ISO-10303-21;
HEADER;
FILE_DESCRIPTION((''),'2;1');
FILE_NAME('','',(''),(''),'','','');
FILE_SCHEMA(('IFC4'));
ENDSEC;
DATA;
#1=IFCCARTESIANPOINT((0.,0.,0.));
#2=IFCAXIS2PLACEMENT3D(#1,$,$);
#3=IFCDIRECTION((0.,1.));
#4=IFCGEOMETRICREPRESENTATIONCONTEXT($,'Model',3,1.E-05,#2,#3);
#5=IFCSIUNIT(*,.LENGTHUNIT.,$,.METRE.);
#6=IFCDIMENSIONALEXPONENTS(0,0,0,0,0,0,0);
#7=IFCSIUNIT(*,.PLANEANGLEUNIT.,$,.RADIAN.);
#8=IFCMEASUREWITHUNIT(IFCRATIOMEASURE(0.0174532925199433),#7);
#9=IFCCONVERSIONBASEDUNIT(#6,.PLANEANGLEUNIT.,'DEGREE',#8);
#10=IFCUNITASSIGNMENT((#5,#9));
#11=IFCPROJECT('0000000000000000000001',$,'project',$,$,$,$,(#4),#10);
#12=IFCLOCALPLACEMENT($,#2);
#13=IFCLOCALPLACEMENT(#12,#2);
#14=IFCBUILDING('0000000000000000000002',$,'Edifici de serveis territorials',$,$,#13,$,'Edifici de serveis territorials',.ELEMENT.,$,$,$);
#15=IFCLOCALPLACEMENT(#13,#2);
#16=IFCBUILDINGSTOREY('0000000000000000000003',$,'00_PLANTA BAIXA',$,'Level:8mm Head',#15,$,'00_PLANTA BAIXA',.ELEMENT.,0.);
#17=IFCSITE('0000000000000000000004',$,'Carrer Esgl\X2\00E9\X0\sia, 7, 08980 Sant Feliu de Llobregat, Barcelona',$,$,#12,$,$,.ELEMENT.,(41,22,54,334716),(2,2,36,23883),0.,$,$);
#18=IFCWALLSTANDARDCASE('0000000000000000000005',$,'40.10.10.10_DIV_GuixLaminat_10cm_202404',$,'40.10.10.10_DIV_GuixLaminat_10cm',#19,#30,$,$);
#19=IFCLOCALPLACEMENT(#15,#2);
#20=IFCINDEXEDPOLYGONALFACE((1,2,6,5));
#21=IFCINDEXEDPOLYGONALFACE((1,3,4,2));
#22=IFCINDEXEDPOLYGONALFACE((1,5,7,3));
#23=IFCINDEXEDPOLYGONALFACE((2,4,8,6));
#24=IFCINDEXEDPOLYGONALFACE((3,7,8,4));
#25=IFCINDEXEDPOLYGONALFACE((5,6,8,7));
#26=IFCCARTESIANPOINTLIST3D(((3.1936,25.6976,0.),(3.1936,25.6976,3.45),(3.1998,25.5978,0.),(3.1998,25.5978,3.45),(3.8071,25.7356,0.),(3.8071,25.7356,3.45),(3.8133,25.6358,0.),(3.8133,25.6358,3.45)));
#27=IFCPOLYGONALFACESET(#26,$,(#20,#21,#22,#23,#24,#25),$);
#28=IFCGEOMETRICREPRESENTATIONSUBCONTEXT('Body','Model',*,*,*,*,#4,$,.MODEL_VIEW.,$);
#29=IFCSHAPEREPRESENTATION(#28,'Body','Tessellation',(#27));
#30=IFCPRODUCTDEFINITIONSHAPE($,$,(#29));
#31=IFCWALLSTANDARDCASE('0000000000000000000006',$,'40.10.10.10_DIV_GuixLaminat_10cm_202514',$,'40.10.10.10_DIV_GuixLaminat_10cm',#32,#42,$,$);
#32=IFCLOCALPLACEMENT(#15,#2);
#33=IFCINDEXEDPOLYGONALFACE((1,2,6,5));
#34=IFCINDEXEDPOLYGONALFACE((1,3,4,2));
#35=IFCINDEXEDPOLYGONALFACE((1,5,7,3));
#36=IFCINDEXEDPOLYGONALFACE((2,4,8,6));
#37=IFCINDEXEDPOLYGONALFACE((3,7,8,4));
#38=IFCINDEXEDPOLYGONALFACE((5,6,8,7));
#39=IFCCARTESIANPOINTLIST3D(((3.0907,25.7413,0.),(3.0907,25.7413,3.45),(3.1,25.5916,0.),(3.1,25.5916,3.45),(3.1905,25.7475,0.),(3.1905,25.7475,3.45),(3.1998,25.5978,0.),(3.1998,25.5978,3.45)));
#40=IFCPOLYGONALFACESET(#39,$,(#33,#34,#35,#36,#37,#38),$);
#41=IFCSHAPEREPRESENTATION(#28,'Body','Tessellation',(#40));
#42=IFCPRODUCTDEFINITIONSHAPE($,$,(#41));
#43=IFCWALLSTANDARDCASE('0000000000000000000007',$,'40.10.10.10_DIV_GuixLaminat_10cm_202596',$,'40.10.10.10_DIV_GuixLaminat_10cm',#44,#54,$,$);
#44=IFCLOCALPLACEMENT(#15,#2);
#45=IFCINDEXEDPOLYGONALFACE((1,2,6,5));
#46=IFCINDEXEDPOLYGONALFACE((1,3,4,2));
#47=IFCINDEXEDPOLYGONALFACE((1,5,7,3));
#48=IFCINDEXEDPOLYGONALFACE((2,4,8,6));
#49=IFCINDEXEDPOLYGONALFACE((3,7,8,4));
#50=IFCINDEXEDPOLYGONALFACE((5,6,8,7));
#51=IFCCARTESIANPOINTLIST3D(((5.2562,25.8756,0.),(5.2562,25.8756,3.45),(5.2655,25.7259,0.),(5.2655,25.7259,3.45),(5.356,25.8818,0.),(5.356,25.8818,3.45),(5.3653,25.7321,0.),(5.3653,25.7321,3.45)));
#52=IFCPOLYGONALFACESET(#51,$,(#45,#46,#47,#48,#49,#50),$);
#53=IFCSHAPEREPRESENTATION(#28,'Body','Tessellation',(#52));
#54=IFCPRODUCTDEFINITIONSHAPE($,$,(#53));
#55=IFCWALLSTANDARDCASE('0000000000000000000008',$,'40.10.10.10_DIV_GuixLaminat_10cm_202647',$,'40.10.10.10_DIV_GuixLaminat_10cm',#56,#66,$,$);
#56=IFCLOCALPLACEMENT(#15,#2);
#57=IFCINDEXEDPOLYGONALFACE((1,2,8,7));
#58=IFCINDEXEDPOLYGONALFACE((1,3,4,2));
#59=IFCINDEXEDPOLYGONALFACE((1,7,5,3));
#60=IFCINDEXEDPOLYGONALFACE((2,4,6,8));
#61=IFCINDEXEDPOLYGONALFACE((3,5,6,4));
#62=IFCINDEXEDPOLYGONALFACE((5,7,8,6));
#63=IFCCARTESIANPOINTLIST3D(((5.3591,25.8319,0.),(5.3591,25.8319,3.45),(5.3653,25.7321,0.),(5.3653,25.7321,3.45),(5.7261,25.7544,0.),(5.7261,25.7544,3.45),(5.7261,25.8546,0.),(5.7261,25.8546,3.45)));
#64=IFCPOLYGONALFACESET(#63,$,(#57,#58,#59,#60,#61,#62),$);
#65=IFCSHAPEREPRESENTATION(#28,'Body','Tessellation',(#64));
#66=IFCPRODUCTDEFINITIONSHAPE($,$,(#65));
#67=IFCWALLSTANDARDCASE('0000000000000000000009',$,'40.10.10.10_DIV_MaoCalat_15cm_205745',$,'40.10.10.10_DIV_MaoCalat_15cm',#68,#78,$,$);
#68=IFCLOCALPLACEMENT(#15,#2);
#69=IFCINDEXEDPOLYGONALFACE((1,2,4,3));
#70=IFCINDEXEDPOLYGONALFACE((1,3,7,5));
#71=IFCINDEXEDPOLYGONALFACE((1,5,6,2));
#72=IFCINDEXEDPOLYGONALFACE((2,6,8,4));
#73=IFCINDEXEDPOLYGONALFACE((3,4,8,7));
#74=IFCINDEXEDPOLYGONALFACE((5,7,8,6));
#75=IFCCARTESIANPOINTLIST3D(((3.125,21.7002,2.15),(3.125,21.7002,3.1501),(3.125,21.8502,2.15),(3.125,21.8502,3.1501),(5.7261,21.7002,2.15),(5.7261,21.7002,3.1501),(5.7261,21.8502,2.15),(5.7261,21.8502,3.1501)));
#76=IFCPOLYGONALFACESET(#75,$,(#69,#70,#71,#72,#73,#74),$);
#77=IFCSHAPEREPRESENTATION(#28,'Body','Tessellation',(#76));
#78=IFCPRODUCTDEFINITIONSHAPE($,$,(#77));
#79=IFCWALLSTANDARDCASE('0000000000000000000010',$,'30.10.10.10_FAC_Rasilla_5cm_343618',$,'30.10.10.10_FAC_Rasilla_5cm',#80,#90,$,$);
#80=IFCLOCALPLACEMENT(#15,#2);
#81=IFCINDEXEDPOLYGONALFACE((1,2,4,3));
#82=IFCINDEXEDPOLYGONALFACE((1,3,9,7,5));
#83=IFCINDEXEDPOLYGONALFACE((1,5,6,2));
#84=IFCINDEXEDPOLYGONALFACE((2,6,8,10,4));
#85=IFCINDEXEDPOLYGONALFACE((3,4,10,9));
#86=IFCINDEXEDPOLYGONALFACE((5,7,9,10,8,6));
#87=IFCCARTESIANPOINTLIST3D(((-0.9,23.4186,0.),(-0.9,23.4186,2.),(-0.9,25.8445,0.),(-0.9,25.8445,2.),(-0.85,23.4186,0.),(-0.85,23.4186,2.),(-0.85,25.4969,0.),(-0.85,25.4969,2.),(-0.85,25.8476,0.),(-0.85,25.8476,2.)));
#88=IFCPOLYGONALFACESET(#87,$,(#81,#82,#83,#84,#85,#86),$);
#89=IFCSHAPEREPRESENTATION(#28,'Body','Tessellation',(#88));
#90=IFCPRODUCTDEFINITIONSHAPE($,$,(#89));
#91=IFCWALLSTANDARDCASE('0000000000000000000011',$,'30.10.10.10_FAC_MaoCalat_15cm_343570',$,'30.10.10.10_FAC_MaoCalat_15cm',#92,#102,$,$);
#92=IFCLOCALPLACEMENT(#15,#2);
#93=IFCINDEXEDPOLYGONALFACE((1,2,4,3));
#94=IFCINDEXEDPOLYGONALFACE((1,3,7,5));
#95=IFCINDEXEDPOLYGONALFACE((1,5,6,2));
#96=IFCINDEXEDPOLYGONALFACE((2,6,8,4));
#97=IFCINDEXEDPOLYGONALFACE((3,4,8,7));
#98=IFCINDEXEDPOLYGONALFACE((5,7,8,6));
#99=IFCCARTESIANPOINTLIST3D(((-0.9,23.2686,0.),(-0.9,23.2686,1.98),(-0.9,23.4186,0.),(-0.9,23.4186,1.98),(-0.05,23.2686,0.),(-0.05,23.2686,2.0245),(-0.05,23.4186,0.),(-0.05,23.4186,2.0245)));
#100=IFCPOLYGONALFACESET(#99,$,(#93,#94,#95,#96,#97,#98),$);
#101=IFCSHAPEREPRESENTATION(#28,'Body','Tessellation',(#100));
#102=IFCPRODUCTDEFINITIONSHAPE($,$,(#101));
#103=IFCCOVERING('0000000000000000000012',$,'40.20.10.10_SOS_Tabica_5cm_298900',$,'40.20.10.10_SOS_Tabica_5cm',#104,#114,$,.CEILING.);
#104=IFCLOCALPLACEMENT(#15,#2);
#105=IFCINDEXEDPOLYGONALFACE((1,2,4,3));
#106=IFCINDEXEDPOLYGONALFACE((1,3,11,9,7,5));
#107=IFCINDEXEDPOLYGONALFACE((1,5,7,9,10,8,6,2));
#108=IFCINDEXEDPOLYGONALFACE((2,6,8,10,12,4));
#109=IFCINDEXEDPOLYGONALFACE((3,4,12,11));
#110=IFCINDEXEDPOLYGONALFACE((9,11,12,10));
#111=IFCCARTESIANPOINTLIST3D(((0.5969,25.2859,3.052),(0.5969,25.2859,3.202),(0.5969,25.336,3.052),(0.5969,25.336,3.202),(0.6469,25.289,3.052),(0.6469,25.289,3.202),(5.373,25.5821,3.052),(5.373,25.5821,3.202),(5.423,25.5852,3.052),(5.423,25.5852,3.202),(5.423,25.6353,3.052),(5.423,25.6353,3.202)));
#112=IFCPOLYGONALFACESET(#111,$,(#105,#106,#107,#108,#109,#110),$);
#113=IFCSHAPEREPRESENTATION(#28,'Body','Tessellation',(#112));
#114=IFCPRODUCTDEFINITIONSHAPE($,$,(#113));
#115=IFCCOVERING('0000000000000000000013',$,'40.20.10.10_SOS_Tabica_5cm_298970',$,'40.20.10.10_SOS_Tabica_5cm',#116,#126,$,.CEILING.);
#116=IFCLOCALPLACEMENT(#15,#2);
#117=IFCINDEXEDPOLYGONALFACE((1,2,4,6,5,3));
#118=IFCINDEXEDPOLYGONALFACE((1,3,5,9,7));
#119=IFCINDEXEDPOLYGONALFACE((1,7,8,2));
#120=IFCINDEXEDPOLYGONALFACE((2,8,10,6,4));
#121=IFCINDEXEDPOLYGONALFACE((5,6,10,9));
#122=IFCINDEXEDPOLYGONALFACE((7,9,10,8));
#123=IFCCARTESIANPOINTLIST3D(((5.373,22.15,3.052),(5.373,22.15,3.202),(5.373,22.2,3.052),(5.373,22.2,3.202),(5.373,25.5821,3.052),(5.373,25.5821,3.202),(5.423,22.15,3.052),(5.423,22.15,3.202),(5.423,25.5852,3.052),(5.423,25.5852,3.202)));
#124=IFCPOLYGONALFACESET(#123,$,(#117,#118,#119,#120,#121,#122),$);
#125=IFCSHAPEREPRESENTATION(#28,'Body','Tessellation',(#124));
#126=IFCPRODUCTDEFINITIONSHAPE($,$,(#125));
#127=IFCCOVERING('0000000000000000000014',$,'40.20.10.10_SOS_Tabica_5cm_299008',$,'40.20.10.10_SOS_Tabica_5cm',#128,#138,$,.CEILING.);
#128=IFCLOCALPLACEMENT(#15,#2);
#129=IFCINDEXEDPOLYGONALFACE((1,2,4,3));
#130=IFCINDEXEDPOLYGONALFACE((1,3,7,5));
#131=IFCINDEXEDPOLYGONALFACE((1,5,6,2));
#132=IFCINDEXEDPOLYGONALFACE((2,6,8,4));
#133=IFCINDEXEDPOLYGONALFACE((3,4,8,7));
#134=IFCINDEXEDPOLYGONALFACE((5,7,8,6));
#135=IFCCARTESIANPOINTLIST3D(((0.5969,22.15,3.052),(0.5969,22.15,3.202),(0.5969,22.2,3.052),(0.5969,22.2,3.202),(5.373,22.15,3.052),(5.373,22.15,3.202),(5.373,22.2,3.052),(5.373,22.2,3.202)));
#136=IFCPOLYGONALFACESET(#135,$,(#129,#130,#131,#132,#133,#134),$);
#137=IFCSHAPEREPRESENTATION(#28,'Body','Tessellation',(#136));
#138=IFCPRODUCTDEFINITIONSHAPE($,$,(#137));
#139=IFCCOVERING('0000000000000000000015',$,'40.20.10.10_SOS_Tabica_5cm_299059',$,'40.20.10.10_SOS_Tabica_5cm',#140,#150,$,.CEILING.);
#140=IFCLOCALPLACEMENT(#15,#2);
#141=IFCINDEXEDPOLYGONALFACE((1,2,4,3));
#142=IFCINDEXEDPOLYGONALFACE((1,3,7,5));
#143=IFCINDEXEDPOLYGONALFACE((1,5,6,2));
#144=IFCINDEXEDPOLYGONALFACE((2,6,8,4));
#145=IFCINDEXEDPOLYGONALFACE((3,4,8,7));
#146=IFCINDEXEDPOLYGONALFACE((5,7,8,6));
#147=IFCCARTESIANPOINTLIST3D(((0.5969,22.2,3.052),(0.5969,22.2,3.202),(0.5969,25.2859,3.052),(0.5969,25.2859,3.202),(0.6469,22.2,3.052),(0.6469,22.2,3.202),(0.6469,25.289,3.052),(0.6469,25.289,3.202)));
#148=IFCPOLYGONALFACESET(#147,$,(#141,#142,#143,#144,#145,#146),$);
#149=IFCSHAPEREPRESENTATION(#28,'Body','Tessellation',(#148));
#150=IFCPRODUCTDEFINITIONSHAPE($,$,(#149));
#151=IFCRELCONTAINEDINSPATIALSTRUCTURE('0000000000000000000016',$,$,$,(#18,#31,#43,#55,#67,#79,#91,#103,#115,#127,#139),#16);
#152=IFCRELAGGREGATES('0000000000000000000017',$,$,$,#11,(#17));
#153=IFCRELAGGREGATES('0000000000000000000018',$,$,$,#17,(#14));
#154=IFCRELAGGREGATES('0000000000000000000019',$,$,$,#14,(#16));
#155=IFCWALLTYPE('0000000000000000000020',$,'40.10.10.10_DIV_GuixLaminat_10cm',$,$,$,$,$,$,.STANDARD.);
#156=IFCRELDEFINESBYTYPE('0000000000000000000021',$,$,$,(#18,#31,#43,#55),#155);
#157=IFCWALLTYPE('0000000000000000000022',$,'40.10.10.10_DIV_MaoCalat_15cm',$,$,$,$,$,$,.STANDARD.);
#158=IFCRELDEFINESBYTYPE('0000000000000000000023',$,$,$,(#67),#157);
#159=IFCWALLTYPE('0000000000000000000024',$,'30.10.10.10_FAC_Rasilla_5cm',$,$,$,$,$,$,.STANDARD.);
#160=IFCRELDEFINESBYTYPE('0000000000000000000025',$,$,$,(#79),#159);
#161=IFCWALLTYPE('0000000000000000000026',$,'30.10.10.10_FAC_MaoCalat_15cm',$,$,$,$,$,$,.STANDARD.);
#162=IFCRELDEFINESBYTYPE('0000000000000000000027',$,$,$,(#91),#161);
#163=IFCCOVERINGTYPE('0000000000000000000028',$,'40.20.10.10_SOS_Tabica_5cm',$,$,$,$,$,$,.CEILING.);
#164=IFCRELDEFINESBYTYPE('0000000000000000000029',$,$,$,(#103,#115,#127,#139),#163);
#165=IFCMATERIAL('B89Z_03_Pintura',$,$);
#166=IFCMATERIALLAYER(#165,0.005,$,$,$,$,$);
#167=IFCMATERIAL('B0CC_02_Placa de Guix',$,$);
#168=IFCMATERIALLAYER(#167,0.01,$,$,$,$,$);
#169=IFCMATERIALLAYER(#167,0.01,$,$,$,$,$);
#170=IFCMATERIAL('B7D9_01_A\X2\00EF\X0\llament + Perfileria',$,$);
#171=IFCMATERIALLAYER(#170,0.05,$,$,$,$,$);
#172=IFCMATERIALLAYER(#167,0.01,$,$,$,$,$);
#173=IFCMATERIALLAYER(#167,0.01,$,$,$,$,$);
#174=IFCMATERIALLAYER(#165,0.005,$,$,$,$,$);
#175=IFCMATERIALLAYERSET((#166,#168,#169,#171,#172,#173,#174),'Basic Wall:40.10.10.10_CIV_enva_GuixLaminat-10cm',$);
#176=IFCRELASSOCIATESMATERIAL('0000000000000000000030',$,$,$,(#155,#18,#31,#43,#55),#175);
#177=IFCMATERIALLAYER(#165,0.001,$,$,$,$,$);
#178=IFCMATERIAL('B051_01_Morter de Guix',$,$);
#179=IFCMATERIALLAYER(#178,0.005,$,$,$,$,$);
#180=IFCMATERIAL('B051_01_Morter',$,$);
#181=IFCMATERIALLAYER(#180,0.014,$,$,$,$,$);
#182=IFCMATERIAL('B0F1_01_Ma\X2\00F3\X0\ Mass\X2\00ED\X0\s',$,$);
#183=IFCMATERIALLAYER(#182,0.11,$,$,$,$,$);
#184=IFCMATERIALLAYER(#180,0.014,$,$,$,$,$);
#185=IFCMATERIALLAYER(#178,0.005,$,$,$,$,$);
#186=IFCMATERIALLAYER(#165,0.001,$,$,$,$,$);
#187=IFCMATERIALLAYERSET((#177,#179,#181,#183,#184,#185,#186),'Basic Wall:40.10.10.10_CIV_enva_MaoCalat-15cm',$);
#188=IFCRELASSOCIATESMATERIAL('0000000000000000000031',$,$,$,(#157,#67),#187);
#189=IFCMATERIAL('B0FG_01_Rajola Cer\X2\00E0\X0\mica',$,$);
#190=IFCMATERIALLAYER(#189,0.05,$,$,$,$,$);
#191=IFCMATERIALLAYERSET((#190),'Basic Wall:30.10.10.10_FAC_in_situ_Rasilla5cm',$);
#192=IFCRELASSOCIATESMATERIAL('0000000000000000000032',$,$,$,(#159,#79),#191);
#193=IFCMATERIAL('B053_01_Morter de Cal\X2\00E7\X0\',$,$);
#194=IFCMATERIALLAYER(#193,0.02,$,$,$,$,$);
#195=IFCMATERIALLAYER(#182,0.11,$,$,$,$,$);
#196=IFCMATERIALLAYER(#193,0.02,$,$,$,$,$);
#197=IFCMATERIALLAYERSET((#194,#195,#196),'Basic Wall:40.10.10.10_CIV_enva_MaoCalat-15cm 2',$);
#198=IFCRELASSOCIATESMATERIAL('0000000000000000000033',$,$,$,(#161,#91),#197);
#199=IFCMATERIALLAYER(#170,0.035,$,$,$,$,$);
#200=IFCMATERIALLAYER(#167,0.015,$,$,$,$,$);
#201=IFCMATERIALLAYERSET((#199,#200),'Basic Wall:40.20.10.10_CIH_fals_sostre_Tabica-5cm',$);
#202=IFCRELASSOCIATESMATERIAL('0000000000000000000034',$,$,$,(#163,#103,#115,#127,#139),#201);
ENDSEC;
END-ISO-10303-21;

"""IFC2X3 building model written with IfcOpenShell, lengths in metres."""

from ifc_helpers import new_model, entity, si_unit, converted_unit, direction, frame, frame_2d, origin, place, context, subcontext, project, spatial, polyline, rectangle, outline, extrude, clip, bounded_halfspace, material, layer, layer_set, layer_usage, type_object, element, save


model = new_model("IFC2X3")

# Units and contexts
model_context = context("Model", 3, precision=1e-05, world=origin(), true_north=direction((0.0, 1.0)))
body_context = subcontext(model_context, "Body", "Model", "MODEL_VIEW")
ifc_project = project(units=[si_unit("LENGTHUNIT", "METRE"), converted_unit("PLANEANGLEUNIT", "DEGREE", entity("IfcRatioMeasure", 0.0174532925199433), si_unit("PLANEANGLEUNIT", "RADIAN"), dimensions=[0, 0, 0, 0, 0, 0, 0])], contexts=[model_context])

# Site, building, storey
site_placement = place(None, origin())
site = spatial("IfcSite", under=ifc_project, at=site_placement, Name="Carrer Església, 7, 08980 Sant Feliu de Llobregat, Barcelona", CompositionType="ELEMENT", RefLatitude=(41, 22, 54, 334716), RefLongitude=(2, 2, 36, 23883), RefElevation=0.0)
building_placement = place(site_placement, origin())
building = spatial("IfcBuilding", under=site, at=building_placement, Name="Edifici de serveis territorials", LongName="Edifici de serveis territorials", CompositionType="ELEMENT")
storey_placement = place(building_placement, origin())
storey = spatial("IfcBuildingStorey", under=building, at=storey_placement, Name="00_PLANTA BAIXA", ObjectType="Level:8mm Head", LongName="00_PLANTA BAIXA", CompositionType="ELEMENT", Elevation=0.0)

# Shared definitions
ifc_material_1 = material(Name="B053_01_Morter de Calç")
ifc_material_2 = material(Name="B0F1_01_Maó Massís")

# Shared definitions
ifc_material_3 = material(Name="B89Z_03_Pintura")
ifc_layer_1 = layer(ifc_material_3, 0.005)
ifc_material_4 = material(Name="B0CC_02_Placa de Guix")
ifc_layer_2 = layer(ifc_material_4, 0.01)
ifc_layer_3 = layer(ifc_material_4, 0.01)
ifc_material_5 = material(Name="B7D9_01_Aïllament + Perfileria")
ifc_layer_4 = layer(ifc_material_5, 0.05)
ifc_layer_5 = layer(ifc_material_4, 0.01)
ifc_layer_6 = layer(ifc_material_4, 0.01)
ifc_layer_7 = layer(ifc_material_3, 0.005)
ifc_layer_set_1 = layer_set([ifc_layer_1, ifc_layer_2, ifc_layer_3, ifc_layer_4, ifc_layer_5, ifc_layer_6, ifc_layer_7], Name="Basic Wall:40.10.10.10_CIV_enva_GuixLaminat-10cm")
wall_type_1 = type_object("IfcWallType", Name="40.10.10.10_DIV_GuixLaminat_10cm", PredefinedType="STANDARD", material=ifc_layer_set_1)

# Walls
ifc_layer_usage_1 = layer_usage(ifc_layer_set_1, "AXIS2", "NEGATIVE", 0.05)
wall_1_placement = place(storey_placement, frame((3.8102, 25.6857, 0.0), z_axis=(0.0, 0.0, 1.0), x_axis=(-0.998083, -0.061896, 0.0)))
element("IfcWallStandardCase", 1, at=wall_1_placement, inside=storey, type_object=wall_type_1, material=ifc_layer_usage_1, Name="40.10.10.10_DIV_GuixLaminat_10cm_202404", ObjectType="40.10.10.10_DIV_GuixLaminat_10cm", context=body_context, shape_type="Clipping", body=[
    clip(extrude(rectangle(XDim=0.6146, YDim=0.1, at=frame_2d((0.3073, 0.0), x_axis=(-1.0, 0.0))), origin(), (0.0, 0.0, 1.0), 3.45), bounded_halfspace(frame((0.0, -0.05, 3.45), z_axis=(0.0, 0.0, -1.0), x_axis=(0.036428, 0.999336, 0.0)), True, frame((0.0, -0.05, 3.45)), polyline([(0.0, 0.0), (0.6146, 0.0), (0.6146, 0.1), (0.0, 0.1), (0.0, 0.0)]))),
])
ifc_layer_usage_2 = layer_usage(ifc_layer_set_1, "AXIS2", "NEGATIVE", 0.05)
wall_2_placement = place(storey_placement, frame((3.1499, 25.5947, 0.0), z_axis=(0.0, 0.0, 1.0), x_axis=(-0.061896, 0.998083, 0.0)))
element("IfcWallStandardCase", 2, at=wall_2_placement, inside=storey, type_object=wall_type_1, material=ifc_layer_usage_2, Name="40.10.10.10_DIV_GuixLaminat_10cm_202514", ObjectType="40.10.10.10_DIV_GuixLaminat_10cm", context=body_context, shape_type="Clipping", body=[
    clip(extrude(rectangle(XDim=0.15, YDim=0.1, at=frame_2d((0.075, 0.0), x_axis=(-1.0, 0.0))), origin(), (0.0, 0.0, 1.0), 3.45), bounded_halfspace(frame((0.0, -0.05, 3.45), z_axis=(0.0, 0.0, -1.0), x_axis=(-0.999336, 0.036428, 0.0)), True, frame((0.0, -0.05, 3.45)), polyline([(0.0, 0.0), (0.1, 0.0), (0.15, 0.0), (0.15, 0.1), (0.0, 0.1), (0.0, 0.0)]))),
])
ifc_layer_usage_3 = layer_usage(ifc_layer_set_1, "AXIS2", "NEGATIVE", 0.05)
wall_3_placement = place(storey_placement, frame((5.3061, 25.8787, 0.0), z_axis=(0.0, 0.0, 1.0), x_axis=(0.061896, -0.998083, 0.0)))
element("IfcWallStandardCase", 3, at=wall_3_placement, inside=storey, type_object=wall_type_1, material=ifc_layer_usage_3, Name="40.10.10.10_DIV_GuixLaminat_10cm_202596", ObjectType="40.10.10.10_DIV_GuixLaminat_10cm", context=body_context, shape_type="Clipping", body=[
    clip(extrude(rectangle(XDim=0.15, YDim=0.1, at=frame_2d((0.075, 0.0), x_axis=(-1.0, 0.0))), origin(), (0.0, 0.0, 1.0), 3.45), bounded_halfspace(frame((0.0, -0.05, 3.45), z_axis=(0.0, 0.0, -1.0), x_axis=(0.999336, -0.036428, 0.0)), True, frame((0.0, -0.05, 3.45)), polyline([(0.0, 0.0), (0.15, 0.0), (0.15, 0.1), (0.05, 0.1), (0.0, 0.1), (0.0, 0.0)]))),
])
ifc_layer_usage_4 = layer_usage(ifc_layer_set_1, "AXIS2", "NEGATIVE", 0.05)
wall_4_placement = place(storey_placement, frame((5.3622, 25.782, 0.0), z_axis=(0.0, 0.0, 1.0), x_axis=(0.998083, 0.061896, 0.0)))
element("IfcWallStandardCase", 4, at=wall_4_placement, inside=storey, type_object=wall_type_1, material=ifc_layer_usage_4, Name="40.10.10.10_DIV_GuixLaminat_10cm_202647", ObjectType="40.10.10.10_DIV_GuixLaminat_10cm", context=body_context, shape_type="Clipping", body=[
    clip(extrude(outline(polyline([(0.3615, -0.05), (0.3677, 0.05), (0.0, 0.05), (0.0, -0.05), (0.3615, -0.05)])), origin(), (0.0, 0.0, 1.0), 3.45), bounded_halfspace(frame((0.0, -0.05, 3.45), z_axis=(0.0, 0.0, -1.0), x_axis=(-0.036428, -0.999336, 0.0)), True, frame((0.0, -0.05, 3.45)), polyline([(0.0, 0.0), (0.3615, 0.0), (0.3677, 0.1), (0.0, 0.1), (0.0, 0.0)]))),
])
ifc_layer_8 = layer(ifc_material_3, 0.001)
ifc_material_6 = material(Name="B051_01_Morter de Guix")
ifc_layer_9 = layer(ifc_material_6, 0.005)
ifc_material_7 = material(Name="B051_01_Morter")
ifc_layer_10 = layer(ifc_material_7, 0.014)
ifc_layer_11 = layer(ifc_material_2, 0.11)
ifc_layer_12 = layer(ifc_material_7, 0.014)
ifc_layer_13 = layer(ifc_material_6, 0.005)
ifc_layer_14 = layer(ifc_material_3, 0.001)
ifc_layer_set_2 = layer_set([ifc_layer_8, ifc_layer_9, ifc_layer_10, ifc_layer_11, ifc_layer_12, ifc_layer_13, ifc_layer_14], Name="Basic Wall:40.10.10.10_CIV_enva_MaoCalat-15cm")
ifc_layer_usage_5 = layer_usage(ifc_layer_set_2, "AXIS2", "NEGATIVE", 0.075)
wall_type_2 = type_object("IfcWallType", Name="40.10.10.10_DIV_MaoCalat_15cm", PredefinedType="STANDARD", material=ifc_layer_set_2)
wall_5_placement = place(storey_placement, frame((5.7261, 21.7752, 2.15), z_axis=(0.0, 0.0, 1.0), x_axis=(-1.0, 0.0, 0.0)))
element("IfcWallStandardCase", 5, at=wall_5_placement, inside=storey, type_object=wall_type_2, material=ifc_layer_usage_5, Name="40.10.10.10_DIV_MaoCalat_15cm_205745", ObjectType="40.10.10.10_DIV_MaoCalat_15cm", context=body_context, shape_type="SweptSolid", body=[
    extrude(rectangle(XDim=2.6011, YDim=0.15, at=frame_2d((1.3005, 0.0), x_axis=(-1.0, 0.0))), origin(), (0.0, 0.0, 1.0), 1.0001),
])
ifc_material_8 = material(Name="B0FG_01_Rajola Ceràmica")
ifc_layer_15 = layer(ifc_material_8, 0.05)
ifc_layer_set_3 = layer_set([ifc_layer_15], Name="Basic Wall:30.10.10.10_FAC_in_situ_Rasilla5cm")
ifc_layer_usage_6 = layer_usage(ifc_layer_set_3, "AXIS2", "NEGATIVE", 0.025)
wall_type_3 = type_object("IfcWallType", Name="30.10.10.10_FAC_Rasilla_5cm", PredefinedType="STANDARD", material=ifc_layer_set_3)
wall_6_placement = place(storey_placement, frame((-0.875, 23.4186, 0.0), z_axis=(0.0, 0.0, 1.0), x_axis=(0.0, 1.0, 0.0)))
element("IfcWallStandardCase", 6, at=wall_6_placement, inside=storey, type_object=wall_type_3, material=ifc_layer_usage_6, Name="30.10.10.10_FAC_Rasilla_5cm_343618", ObjectType="30.10.10.10_FAC_Rasilla_5cm", context=body_context, shape_type="SweptSolid", body=[
    extrude(outline(polyline([(2.429, -0.025), (2.4259, 0.025), (0.0, 0.025), (0.0, -0.025), (2.0783, -0.025), (2.429, -0.025)])), origin(), (0.0, 0.0, 1.0), 2.0),
])
ifc_layer_16 = layer(ifc_material_1, 0.02)
ifc_layer_17 = layer(ifc_material_2, 0.11)
ifc_layer_18 = layer(ifc_material_1, 0.02)
ifc_layer_set_4 = layer_set([ifc_layer_16, ifc_layer_17, ifc_layer_18], Name="Basic Wall:40.10.10.10_CIV_enva_MaoCalat-15cm 2")
ifc_layer_usage_7 = layer_usage(ifc_layer_set_4, "AXIS2", "NEGATIVE", 0.075)
wall_type_4 = type_object("IfcWallType", Name="30.10.10.10_FAC_MaoCalat_15cm", PredefinedType="STANDARD", material=ifc_layer_set_4)
wall_7_placement = place(storey_placement, frame((-0.05, 23.3436, 0.0), z_axis=(0.0, 0.0, 1.0), x_axis=(-1.0, 0.0, 0.0)))
element("IfcWallStandardCase", 7, at=wall_7_placement, inside=storey, type_object=wall_type_4, material=ifc_layer_usage_7, Name="30.10.10.10_FAC_MaoCalat_15cm_343570", ObjectType="30.10.10.10_FAC_MaoCalat_15cm", context=body_context, shape_type="Clipping", body=[
    clip(extrude(rectangle(XDim=0.85, YDim=0.15, at=frame_2d((0.425, 0.0), x_axis=(-1.0, 0.0))), origin(), (0.0, 0.0, 1.0), 2.0245), bounded_halfspace(frame((0.0, -0.075, 2.0245), z_axis=(-0.052336, 0.0, -0.99863), x_axis=(0.0, 1.0, 0.0)), True, frame((0.0, -0.075, 2.0245)), polyline([(0.0, 0.0), (0.85, 0.0), (0.85, 0.15), (0.0, 0.15), (0.0, 0.0)]))),
])

# Coverings
ifc_layer_19 = layer(ifc_material_5, 0.035)
ifc_layer_20 = layer(ifc_material_4, 0.015)
ifc_layer_set_5 = layer_set([ifc_layer_19, ifc_layer_20], Name="Basic Wall:40.20.10.10_CIH_fals_sostre_Tabica-5cm")
ifc_layer_usage_8 = layer_usage(ifc_layer_set_5, "AXIS2", "POSITIVE", -0.025)
covering_type_1 = type_object("IfcCoveringType", Name="40.20.10.10_SOS_Tabica_5cm", PredefinedType="CEILING", material=ifc_layer_set_5)
covering_1_placement = place(storey_placement, frame((0.5954, 25.3108, 3.052), z_axis=(0.0, 0.0, 1.0), x_axis=(0.998083, 0.061896, 0.0)))
element("IfcCovering", 8, at=covering_1_placement, inside=storey, type_object=covering_type_1, material=ifc_layer_usage_8, Name="40.20.10.10_SOS_Tabica_5cm_298900", ObjectType="40.20.10.10_SOS_Tabica_5cm", PredefinedType="CEILING", context=body_context, shape_type="SweptSolid", body=[
    extrude(outline(polyline([(4.8354, -0.025), (4.8385, 0.025), (0.0031, 0.025), (0.0, -0.025), (0.0501, -0.025), (4.7853, -0.025), (4.8354, -0.025)])), origin(), (0.0, 0.0, 1.0), 0.15),
])
ifc_layer_usage_9 = layer_usage(ifc_layer_set_5, "AXIS2", "POSITIVE", -0.025)
covering_2_placement = place(storey_placement, frame((5.398, 25.5852, 3.052), z_axis=(0.0, 0.0, 1.0), x_axis=(0.0, -1.0, 0.0)))
element("IfcCovering", 9, at=covering_2_placement, inside=storey, type_object=covering_type_1, material=ifc_layer_usage_9, Name="40.20.10.10_SOS_Tabica_5cm_298970", ObjectType="40.20.10.10_SOS_Tabica_5cm", PredefinedType="CEILING", context=body_context, shape_type="SweptSolid", body=[
    extrude(outline(polyline([(3.4352, -0.025), (3.4352, 0.025), (0.0, 0.025), (0.0031, -0.025), (3.3852, -0.025), (3.4352, -0.025)])), origin(), (0.0, 0.0, 1.0), 0.15),
])
ifc_layer_usage_10 = layer_usage(ifc_layer_set_5, "AXIS2", "POSITIVE", -0.025)
covering_3_placement = place(storey_placement, frame((5.373, 22.175, 3.052), z_axis=(0.0, 0.0, 1.0), x_axis=(-1.0, 0.0, 0.0)))
element("IfcCovering", 10, at=covering_3_placement, inside=storey, type_object=covering_type_1, material=ifc_layer_usage_10, Name="40.20.10.10_SOS_Tabica_5cm_299008", ObjectType="40.20.10.10_SOS_Tabica_5cm", PredefinedType="CEILING", context=body_context, shape_type="SweptSolid", body=[
    extrude(rectangle(XDim=4.7761, YDim=0.05, at=frame_2d((2.388, 0.0), x_axis=(-1.0, 0.0))), origin(), (0.0, 0.0, 1.0), 0.15),
])
ifc_layer_usage_11 = layer_usage(ifc_layer_set_5, "AXIS2", "POSITIVE", -0.025)
covering_4_placement = place(storey_placement, frame((0.6219, 22.2, 3.052), z_axis=(0.0, 0.0, 1.0), x_axis=(0.0, 1.0, 0.0)))
element("IfcCovering", 11, at=covering_4_placement, inside=storey, type_object=covering_type_1, material=ifc_layer_usage_11, Name="40.20.10.10_SOS_Tabica_5cm_299059", ObjectType="40.20.10.10_SOS_Tabica_5cm", PredefinedType="CEILING", context=body_context, shape_type="SweptSolid", body=[
    extrude(outline(polyline([(3.089, -0.025), (3.0859, 0.025), (0.0, 0.025), (0.0, -0.025), (3.089, -0.025)])), origin(), (0.0, 0.0, 1.0), 0.15),
])

save(model, "model.ifc")
